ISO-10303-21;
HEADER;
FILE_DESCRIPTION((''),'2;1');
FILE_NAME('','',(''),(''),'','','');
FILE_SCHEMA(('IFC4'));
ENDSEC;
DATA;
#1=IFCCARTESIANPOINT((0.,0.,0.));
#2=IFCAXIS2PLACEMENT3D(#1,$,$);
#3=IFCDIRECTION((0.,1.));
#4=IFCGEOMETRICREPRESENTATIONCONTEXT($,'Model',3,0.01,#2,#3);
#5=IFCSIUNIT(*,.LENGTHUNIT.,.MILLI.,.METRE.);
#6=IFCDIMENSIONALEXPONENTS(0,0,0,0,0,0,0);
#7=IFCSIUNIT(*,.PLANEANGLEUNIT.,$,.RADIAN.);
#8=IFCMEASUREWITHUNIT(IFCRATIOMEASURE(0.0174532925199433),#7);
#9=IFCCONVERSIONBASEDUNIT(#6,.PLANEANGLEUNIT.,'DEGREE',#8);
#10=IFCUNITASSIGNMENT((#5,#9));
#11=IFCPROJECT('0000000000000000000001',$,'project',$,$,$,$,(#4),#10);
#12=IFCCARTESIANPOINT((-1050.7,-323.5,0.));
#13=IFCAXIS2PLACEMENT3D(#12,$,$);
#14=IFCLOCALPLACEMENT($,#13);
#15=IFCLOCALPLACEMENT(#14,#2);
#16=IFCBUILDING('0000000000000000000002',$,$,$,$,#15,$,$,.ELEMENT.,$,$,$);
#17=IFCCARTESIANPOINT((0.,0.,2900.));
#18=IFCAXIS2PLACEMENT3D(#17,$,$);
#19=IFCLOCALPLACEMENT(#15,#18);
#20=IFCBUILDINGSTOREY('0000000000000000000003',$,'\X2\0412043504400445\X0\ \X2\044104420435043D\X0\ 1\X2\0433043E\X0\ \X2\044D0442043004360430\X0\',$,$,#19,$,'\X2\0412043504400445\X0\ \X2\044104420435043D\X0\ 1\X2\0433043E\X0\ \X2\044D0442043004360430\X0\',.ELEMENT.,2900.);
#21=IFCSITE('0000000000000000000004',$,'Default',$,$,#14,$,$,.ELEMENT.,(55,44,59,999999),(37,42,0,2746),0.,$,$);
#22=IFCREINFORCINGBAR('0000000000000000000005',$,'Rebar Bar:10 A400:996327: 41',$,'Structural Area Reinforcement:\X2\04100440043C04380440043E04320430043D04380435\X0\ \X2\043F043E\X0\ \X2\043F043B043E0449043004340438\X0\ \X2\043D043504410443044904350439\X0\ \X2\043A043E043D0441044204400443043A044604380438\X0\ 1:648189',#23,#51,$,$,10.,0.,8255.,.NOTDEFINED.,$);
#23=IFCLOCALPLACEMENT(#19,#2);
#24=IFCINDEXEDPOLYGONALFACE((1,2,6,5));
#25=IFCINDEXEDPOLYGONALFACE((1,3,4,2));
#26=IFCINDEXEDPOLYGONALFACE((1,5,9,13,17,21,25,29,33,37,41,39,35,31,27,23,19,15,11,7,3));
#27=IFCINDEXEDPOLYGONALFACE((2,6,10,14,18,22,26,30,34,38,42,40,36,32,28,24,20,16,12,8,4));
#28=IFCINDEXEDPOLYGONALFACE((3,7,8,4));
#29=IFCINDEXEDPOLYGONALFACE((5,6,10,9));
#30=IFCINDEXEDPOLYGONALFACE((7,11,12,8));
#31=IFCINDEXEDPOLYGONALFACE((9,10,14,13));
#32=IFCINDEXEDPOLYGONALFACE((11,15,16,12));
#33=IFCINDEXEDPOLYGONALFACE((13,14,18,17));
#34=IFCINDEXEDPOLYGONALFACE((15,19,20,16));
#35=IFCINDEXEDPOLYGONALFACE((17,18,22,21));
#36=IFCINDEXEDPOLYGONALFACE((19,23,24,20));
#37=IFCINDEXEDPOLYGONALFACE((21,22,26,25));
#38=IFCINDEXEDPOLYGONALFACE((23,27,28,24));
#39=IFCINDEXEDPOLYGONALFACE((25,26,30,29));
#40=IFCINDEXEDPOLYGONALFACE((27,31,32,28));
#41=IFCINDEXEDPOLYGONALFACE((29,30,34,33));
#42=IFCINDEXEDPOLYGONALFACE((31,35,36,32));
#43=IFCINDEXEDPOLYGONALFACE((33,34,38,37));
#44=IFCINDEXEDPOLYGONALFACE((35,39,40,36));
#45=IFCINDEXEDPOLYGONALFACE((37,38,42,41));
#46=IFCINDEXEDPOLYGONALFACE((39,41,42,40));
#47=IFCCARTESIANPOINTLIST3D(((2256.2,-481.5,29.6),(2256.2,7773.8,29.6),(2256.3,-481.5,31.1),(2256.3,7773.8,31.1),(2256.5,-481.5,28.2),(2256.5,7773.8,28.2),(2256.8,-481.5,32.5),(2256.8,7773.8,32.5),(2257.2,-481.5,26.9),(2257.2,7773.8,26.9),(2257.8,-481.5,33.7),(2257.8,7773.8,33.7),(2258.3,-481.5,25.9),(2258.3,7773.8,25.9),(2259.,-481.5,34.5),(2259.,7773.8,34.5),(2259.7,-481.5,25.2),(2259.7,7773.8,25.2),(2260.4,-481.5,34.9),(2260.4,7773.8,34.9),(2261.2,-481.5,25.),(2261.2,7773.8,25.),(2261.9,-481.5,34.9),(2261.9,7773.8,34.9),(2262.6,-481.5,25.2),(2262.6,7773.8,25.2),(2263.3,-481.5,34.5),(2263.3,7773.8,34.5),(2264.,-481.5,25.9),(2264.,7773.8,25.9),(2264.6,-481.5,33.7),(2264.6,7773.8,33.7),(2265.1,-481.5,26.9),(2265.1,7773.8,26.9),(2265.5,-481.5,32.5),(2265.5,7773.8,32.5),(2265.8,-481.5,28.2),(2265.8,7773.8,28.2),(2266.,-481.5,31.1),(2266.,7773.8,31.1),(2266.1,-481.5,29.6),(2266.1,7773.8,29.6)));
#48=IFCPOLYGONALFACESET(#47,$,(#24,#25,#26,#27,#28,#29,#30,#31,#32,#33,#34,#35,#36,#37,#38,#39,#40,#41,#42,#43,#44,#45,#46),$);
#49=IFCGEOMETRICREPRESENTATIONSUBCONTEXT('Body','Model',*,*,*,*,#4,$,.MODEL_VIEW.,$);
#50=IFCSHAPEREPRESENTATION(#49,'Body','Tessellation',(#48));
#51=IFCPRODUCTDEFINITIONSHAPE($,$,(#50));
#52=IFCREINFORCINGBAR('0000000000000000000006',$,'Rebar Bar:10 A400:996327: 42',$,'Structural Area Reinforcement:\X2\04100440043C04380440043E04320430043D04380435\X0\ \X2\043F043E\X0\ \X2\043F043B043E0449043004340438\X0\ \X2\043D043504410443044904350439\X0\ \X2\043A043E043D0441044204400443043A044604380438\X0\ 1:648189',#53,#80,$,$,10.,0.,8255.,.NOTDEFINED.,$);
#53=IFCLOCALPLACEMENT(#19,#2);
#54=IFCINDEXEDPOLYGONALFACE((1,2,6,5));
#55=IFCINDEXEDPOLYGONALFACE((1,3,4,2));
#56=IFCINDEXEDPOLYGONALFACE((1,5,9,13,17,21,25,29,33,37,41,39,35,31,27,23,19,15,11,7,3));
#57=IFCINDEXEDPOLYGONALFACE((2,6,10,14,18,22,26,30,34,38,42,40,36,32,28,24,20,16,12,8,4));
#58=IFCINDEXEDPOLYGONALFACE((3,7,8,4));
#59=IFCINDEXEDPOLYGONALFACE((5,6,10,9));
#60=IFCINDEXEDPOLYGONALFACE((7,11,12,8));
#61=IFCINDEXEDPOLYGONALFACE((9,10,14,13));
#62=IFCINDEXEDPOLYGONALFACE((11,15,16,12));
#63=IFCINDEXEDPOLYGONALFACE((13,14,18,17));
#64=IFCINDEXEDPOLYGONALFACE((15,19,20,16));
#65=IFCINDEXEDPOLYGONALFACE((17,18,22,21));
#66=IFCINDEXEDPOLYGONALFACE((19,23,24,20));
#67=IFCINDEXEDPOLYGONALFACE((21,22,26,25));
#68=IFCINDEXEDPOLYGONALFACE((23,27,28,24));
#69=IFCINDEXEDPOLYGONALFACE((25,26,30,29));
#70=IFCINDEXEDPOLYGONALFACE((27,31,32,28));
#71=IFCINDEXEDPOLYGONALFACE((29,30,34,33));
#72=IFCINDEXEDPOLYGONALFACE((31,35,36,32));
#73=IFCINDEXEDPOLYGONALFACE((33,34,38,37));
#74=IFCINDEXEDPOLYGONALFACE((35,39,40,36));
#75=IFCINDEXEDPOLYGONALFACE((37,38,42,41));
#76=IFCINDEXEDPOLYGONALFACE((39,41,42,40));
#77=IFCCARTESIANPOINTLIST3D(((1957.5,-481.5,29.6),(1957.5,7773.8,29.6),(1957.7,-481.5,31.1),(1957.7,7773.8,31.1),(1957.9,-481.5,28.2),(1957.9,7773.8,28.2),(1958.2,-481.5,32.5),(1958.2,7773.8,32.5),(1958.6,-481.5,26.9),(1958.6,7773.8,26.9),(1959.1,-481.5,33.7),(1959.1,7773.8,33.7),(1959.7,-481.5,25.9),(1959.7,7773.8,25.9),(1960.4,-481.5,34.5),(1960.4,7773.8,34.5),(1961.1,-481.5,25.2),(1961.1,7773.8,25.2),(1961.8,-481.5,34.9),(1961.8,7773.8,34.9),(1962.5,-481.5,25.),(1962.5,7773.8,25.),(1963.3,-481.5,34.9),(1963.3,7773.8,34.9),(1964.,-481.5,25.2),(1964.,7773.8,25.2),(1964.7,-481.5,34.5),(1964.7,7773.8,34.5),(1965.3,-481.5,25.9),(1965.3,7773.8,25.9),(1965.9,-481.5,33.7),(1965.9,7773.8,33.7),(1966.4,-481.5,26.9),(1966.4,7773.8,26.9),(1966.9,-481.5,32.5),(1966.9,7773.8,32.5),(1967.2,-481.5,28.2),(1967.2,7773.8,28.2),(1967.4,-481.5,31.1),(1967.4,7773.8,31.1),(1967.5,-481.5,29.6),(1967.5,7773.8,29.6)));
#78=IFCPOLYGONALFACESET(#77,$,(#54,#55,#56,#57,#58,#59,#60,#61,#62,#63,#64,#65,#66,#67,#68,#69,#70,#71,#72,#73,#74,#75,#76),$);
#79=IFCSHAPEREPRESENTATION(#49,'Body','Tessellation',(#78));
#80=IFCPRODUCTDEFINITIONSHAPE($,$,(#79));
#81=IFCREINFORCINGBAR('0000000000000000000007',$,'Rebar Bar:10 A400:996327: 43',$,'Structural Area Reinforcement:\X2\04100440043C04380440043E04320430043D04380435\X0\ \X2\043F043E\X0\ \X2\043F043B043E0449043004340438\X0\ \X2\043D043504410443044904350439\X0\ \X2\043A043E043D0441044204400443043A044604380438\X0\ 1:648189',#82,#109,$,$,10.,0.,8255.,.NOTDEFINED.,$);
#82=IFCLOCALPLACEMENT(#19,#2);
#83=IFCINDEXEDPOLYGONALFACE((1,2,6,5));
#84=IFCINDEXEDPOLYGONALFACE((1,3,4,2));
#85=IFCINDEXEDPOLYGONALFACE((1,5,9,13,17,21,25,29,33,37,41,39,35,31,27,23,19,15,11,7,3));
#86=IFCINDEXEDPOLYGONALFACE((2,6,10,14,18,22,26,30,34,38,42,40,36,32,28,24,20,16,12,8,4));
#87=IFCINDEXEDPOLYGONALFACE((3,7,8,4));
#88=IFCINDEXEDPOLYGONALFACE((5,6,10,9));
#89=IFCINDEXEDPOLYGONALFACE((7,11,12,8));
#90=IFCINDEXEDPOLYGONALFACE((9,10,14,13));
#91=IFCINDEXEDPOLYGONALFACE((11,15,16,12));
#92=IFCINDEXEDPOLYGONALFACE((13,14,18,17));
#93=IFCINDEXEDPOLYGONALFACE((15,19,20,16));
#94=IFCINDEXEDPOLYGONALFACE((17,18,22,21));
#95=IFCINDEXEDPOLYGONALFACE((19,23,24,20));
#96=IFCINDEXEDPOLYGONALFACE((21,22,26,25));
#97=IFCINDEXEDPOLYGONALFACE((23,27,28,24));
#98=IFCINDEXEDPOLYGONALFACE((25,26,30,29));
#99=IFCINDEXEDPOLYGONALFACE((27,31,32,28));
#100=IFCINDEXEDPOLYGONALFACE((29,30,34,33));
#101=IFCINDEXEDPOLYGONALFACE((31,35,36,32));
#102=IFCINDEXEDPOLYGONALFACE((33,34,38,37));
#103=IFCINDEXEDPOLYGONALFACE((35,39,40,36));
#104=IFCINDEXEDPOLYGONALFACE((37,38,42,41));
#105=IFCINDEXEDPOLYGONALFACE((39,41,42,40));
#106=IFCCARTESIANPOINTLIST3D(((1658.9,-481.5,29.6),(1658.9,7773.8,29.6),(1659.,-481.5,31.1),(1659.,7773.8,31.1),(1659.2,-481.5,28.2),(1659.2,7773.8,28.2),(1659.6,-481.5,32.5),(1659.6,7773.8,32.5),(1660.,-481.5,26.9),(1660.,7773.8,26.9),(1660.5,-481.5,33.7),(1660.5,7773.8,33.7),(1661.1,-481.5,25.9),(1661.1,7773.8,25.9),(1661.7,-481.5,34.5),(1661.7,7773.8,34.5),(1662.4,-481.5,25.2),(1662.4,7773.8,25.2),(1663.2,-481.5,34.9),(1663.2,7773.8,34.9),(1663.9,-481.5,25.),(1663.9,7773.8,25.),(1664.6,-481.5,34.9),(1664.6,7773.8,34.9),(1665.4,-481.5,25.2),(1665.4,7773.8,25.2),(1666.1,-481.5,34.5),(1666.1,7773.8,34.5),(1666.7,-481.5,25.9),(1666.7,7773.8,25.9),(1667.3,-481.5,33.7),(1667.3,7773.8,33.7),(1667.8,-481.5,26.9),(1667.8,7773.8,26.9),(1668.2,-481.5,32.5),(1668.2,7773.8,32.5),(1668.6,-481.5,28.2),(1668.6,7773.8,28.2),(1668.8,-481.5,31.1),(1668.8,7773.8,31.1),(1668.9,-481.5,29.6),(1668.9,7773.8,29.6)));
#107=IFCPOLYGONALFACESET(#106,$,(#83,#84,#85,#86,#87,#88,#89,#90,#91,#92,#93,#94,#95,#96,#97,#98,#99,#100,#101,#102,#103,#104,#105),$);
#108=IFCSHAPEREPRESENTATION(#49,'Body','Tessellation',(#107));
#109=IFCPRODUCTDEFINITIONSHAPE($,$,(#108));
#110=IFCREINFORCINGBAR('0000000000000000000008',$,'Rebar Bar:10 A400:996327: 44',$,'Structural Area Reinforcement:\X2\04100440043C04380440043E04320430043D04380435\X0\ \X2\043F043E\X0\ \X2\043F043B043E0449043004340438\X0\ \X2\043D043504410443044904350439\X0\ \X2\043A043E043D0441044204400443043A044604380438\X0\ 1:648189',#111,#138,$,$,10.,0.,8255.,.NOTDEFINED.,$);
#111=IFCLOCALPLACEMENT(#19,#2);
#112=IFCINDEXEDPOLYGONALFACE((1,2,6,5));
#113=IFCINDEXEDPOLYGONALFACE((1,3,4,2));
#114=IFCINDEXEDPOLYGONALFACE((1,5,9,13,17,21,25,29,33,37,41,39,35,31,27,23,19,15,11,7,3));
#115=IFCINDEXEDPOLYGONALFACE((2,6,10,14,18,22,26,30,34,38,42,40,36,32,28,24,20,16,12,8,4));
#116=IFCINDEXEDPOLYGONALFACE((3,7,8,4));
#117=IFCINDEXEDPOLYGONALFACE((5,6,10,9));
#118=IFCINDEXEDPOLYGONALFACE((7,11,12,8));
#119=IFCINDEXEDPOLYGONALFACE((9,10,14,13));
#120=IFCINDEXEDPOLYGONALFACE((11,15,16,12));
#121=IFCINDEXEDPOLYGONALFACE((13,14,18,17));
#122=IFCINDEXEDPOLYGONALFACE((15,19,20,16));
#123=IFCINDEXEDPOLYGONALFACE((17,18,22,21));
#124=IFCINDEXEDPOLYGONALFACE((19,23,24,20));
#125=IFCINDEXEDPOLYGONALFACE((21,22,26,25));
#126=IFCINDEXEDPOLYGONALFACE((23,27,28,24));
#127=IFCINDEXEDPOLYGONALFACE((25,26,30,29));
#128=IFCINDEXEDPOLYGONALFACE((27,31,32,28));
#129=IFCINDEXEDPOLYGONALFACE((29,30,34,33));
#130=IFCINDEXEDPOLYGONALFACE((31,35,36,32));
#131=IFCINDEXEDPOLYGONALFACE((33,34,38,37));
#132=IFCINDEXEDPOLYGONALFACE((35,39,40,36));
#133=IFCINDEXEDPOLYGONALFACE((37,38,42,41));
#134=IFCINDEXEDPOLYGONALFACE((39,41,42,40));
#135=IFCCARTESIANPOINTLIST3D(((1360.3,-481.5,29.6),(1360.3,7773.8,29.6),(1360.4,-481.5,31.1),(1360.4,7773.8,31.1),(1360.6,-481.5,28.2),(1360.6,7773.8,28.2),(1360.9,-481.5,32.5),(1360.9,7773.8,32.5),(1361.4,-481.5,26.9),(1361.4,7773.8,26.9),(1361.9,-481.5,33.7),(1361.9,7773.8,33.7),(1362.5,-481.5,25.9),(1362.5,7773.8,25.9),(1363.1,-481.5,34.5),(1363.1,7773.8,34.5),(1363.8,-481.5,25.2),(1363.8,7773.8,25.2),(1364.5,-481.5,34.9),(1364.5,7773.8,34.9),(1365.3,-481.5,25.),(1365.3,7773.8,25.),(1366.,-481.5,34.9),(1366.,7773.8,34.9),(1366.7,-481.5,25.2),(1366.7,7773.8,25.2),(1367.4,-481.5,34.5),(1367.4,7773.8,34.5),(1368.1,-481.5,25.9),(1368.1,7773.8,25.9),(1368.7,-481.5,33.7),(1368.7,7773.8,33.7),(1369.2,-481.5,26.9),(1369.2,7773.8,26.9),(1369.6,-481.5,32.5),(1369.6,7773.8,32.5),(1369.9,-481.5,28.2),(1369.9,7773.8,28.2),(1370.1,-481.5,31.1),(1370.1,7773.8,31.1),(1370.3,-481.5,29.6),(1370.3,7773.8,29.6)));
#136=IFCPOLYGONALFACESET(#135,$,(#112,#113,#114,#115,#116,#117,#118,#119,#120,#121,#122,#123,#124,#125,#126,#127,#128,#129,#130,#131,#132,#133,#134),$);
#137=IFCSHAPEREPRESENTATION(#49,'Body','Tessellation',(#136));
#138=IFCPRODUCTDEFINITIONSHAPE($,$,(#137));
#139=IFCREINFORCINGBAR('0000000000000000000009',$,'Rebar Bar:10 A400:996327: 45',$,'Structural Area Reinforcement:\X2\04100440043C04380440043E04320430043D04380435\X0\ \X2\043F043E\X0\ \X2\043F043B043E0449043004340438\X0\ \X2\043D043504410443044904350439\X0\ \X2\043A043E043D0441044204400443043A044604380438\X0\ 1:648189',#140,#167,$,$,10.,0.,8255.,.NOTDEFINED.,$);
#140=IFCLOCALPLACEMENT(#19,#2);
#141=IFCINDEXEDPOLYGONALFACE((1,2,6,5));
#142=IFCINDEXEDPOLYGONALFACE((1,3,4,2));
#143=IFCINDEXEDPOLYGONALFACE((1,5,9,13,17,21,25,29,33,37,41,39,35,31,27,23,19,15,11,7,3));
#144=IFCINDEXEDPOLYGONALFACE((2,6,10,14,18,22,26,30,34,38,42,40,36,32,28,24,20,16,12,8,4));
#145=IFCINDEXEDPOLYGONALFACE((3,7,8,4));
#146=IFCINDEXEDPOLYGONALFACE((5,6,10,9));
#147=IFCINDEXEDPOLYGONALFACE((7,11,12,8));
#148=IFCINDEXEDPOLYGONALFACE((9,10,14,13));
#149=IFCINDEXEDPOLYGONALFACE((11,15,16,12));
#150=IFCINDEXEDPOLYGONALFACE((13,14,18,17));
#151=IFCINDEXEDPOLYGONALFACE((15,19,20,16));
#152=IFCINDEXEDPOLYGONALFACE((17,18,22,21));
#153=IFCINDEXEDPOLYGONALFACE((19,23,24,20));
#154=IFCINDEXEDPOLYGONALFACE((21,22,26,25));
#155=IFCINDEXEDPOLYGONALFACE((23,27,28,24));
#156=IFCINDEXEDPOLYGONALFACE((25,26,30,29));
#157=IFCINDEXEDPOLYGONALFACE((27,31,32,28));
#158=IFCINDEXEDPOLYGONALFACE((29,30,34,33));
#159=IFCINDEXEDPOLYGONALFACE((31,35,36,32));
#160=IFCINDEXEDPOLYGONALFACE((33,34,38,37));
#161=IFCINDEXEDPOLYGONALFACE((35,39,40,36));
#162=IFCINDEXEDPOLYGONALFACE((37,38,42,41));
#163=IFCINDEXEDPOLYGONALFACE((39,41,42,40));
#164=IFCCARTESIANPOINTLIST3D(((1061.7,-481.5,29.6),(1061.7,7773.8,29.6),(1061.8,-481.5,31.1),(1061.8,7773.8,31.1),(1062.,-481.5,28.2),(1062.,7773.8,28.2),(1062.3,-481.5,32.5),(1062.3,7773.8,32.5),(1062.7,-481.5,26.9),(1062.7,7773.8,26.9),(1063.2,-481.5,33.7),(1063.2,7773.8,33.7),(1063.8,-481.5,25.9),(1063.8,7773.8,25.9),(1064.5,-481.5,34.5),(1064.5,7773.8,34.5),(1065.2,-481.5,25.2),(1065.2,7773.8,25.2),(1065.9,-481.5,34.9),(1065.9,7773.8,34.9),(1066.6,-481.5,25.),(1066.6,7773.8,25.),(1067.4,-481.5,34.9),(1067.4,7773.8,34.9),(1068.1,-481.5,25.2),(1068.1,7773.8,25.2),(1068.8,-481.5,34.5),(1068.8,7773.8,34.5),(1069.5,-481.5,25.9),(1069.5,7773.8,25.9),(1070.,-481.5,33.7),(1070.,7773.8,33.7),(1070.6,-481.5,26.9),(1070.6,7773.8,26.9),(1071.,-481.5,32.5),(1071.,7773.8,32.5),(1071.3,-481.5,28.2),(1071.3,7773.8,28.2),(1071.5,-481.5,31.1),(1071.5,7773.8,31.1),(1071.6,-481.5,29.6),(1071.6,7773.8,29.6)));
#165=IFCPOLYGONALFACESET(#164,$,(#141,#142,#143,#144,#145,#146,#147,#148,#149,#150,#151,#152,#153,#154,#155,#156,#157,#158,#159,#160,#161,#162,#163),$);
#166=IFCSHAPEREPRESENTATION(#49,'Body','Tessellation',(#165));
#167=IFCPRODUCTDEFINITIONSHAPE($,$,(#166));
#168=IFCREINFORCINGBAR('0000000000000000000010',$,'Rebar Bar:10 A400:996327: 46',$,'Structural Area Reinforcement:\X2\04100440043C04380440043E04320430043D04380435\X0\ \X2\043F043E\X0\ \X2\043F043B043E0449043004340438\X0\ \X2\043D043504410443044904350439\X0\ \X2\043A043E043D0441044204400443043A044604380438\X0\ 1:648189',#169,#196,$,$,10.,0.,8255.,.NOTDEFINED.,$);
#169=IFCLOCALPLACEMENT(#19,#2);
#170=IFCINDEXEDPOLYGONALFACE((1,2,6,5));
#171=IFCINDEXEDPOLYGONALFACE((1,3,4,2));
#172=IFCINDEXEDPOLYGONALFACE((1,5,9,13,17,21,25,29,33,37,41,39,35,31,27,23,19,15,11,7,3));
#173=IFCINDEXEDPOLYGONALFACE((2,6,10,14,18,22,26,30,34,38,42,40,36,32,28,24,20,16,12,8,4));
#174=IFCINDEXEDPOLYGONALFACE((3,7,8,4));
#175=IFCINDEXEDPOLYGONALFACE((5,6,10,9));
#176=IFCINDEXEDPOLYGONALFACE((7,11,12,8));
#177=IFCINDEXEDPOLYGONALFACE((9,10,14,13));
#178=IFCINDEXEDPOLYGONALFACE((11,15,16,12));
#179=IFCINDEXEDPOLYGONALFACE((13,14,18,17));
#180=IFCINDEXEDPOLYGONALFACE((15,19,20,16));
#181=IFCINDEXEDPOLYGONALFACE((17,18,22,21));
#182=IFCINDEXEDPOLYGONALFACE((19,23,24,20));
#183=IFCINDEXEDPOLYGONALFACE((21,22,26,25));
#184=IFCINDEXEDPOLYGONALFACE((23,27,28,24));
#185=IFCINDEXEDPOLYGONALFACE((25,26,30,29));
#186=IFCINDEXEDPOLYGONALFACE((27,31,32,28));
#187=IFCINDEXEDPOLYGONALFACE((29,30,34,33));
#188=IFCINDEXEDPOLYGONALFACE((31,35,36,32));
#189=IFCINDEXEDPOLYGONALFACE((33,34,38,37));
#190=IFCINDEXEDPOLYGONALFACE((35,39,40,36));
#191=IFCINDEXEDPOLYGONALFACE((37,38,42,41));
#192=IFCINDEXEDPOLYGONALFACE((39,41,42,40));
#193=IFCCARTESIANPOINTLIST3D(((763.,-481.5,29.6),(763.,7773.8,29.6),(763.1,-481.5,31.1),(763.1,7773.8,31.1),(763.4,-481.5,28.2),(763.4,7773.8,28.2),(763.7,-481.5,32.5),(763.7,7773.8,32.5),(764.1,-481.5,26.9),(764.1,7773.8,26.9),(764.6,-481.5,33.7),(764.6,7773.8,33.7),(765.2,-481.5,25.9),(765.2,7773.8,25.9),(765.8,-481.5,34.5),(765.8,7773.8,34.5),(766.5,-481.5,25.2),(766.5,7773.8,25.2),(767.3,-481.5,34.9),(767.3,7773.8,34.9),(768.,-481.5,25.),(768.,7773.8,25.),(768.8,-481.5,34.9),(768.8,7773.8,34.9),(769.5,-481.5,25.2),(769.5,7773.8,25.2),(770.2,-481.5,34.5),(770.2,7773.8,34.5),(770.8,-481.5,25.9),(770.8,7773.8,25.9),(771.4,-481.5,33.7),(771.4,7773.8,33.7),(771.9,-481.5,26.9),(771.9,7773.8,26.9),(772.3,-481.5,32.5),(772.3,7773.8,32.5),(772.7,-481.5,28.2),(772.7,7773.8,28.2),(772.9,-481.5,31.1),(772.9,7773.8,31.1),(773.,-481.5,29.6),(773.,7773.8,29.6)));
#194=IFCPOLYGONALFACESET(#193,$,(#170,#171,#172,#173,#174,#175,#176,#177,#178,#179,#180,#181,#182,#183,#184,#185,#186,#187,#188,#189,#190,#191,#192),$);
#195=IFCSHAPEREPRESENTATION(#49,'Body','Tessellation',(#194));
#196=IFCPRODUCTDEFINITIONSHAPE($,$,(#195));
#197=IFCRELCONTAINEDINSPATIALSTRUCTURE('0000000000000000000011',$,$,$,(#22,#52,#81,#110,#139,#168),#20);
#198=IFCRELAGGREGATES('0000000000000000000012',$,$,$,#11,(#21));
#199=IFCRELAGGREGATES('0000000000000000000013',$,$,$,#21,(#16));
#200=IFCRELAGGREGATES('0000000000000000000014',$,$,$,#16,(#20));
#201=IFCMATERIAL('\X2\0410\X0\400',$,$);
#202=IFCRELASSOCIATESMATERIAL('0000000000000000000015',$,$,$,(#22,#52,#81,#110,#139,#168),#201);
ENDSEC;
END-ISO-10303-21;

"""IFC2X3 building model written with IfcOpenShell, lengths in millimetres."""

from ifc_helpers import new_model, entity, si_unit, converted_unit, direction, frame, origin, place, context, subcontext, project, spatial, material, element, save


model = new_model("IFC2X3")

# Units and contexts
model_context = context("Model", 3, precision=0.01, world=origin(), true_north=direction((0.0, 1.0)))
body_context = subcontext(model_context, "Body", "Model", "MODEL_VIEW")
ifc_project = project(units=[si_unit("LENGTHUNIT", "METRE", prefix="MILLI"), converted_unit("PLANEANGLEUNIT", "DEGREE", entity("IfcRatioMeasure", 0.0174532925199433), si_unit("PLANEANGLEUNIT", "RADIAN"), dimensions=[0, 0, 0, 0, 0, 0, 0])], contexts=[model_context])

# Site, building, storey
site_placement = place(None, frame((-1050.7, -323.5, 0.0)))
site = spatial("IfcSite", under=ifc_project, at=site_placement, Name="Default", CompositionType="ELEMENT", RefLatitude=(55, 44, 59, 999999), RefLongitude=(37, 42, 0, 2746), RefElevation=0.0)
building_placement = place(site_placement, origin())
building = spatial("IfcBuilding", under=site, at=building_placement, CompositionType="ELEMENT")
storey_placement = place(building_placement, frame((0.0, 0.0, 2900.0)))
storey = spatial("IfcBuildingStorey", under=building, at=storey_placement, Name="Верх стен 1го этажа", LongName="Верх стен 1го этажа", CompositionType="ELEMENT", Elevation=2900.0)

# Reinforcing bars
ifc_material = material(Name="А400")
reinforcing_bar_1_placement = place(storey_placement, origin())
element("IfcReinforcingBar", 1, at=reinforcing_bar_1_placement, inside=storey, material=ifc_material, Name="Rebar Bar:10 A400:996327: 41", ObjectType="Structural Area Reinforcement:Армирование по площади несущей конструкции 1:648189", BarLength=8255.0, BarRole="NOTDEFINED", CrossSectionArea=0.0, NominalDiameter=10.0, context=body_context, shape_type="AdvancedSweptSolid", body=[
    entity("IfcSweptDiskSolid", entity("IfcCompositeCurve", [entity("IfcCompositeCurveSegment", "CONTINUOUS", True, entity("IfcPolyline", [entity("IfcCartesianPoint", [2261.2, 7773.8, 30.0]), entity("IfcCartesianPoint", [2261.2, -481.5, 30.0])]))], False), 5.0, None, 0.0, 1.0),
])
reinforcing_bar_2_placement = place(storey_placement, origin())
element("IfcReinforcingBar", 2, at=reinforcing_bar_2_placement, inside=storey, material=ifc_material, Name="Rebar Bar:10 A400:996327: 42", ObjectType="Structural Area Reinforcement:Армирование по площади несущей конструкции 1:648189", BarLength=8255.0, BarRole="NOTDEFINED", CrossSectionArea=0.0, NominalDiameter=10.0, context=body_context, shape_type="AdvancedSweptSolid", body=[
    entity("IfcSweptDiskSolid", entity("IfcCompositeCurve", [entity("IfcCompositeCurveSegment", "CONTINUOUS", True, entity("IfcPolyline", [entity("IfcCartesianPoint", [1962.5, 7773.8, 30.0]), entity("IfcCartesianPoint", [1962.5, -481.5, 30.0])]))], False), 5.0, None, 0.0, 1.0),
])
reinforcing_bar_3_placement = place(storey_placement, origin())
element("IfcReinforcingBar", 3, at=reinforcing_bar_3_placement, inside=storey, material=ifc_material, Name="Rebar Bar:10 A400:996327: 43", ObjectType="Structural Area Reinforcement:Армирование по площади несущей конструкции 1:648189", BarLength=8255.0, BarRole="NOTDEFINED", CrossSectionArea=0.0, NominalDiameter=10.0, context=body_context, shape_type="AdvancedSweptSolid", body=[
    entity("IfcSweptDiskSolid", entity("IfcCompositeCurve", [entity("IfcCompositeCurveSegment", "CONTINUOUS", True, entity("IfcPolyline", [entity("IfcCartesianPoint", [1663.9, 7773.8, 30.0]), entity("IfcCartesianPoint", [1663.9, -481.5, 30.0])]))], False), 5.0, None, 0.0, 1.0),
])
reinforcing_bar_4_placement = place(storey_placement, origin())
element("IfcReinforcingBar", 4, at=reinforcing_bar_4_placement, inside=storey, material=ifc_material, Name="Rebar Bar:10 A400:996327: 44", ObjectType="Structural Area Reinforcement:Армирование по площади несущей конструкции 1:648189", BarLength=8255.0, BarRole="NOTDEFINED", CrossSectionArea=0.0, NominalDiameter=10.0, context=body_context, shape_type="AdvancedSweptSolid", body=[
    entity("IfcSweptDiskSolid", entity("IfcCompositeCurve", [entity("IfcCompositeCurveSegment", "CONTINUOUS", True, entity("IfcPolyline", [entity("IfcCartesianPoint", [1365.3, 7773.8, 30.0]), entity("IfcCartesianPoint", [1365.3, -481.5, 30.0])]))], False), 5.0, None, 0.0, 1.0),
])
reinforcing_bar_5_placement = place(storey_placement, origin())
element("IfcReinforcingBar", 5, at=reinforcing_bar_5_placement, inside=storey, material=ifc_material, Name="Rebar Bar:10 A400:996327: 45", ObjectType="Structural Area Reinforcement:Армирование по площади несущей конструкции 1:648189", BarLength=8255.0, BarRole="NOTDEFINED", CrossSectionArea=0.0, NominalDiameter=10.0, context=body_context, shape_type="AdvancedSweptSolid", body=[
    entity("IfcSweptDiskSolid", entity("IfcCompositeCurve", [entity("IfcCompositeCurveSegment", "CONTINUOUS", True, entity("IfcPolyline", [entity("IfcCartesianPoint", [1066.6, 7773.8, 30.0]), entity("IfcCartesianPoint", [1066.6, -481.5, 30.0])]))], False), 5.0, None, 0.0, 1.0),
])
reinforcing_bar_6_placement = place(storey_placement, origin())
element("IfcReinforcingBar", 6, at=reinforcing_bar_6_placement, inside=storey, material=ifc_material, Name="Rebar Bar:10 A400:996327: 46", ObjectType="Structural Area Reinforcement:Армирование по площади несущей конструкции 1:648189", BarLength=8255.0, BarRole="NOTDEFINED", CrossSectionArea=0.0, NominalDiameter=10.0, context=body_context, shape_type="AdvancedSweptSolid", body=[
    entity("IfcSweptDiskSolid", entity("IfcCompositeCurve", [entity("IfcCompositeCurveSegment", "CONTINUOUS", True, entity("IfcPolyline", [entity("IfcCartesianPoint", [768.0, 7773.8, 30.0]), entity("IfcCartesianPoint", [768.0, -481.5, 30.0])]))], False), 5.0, None, 0.0, 1.0),
])

save(model, "model.ifc")
